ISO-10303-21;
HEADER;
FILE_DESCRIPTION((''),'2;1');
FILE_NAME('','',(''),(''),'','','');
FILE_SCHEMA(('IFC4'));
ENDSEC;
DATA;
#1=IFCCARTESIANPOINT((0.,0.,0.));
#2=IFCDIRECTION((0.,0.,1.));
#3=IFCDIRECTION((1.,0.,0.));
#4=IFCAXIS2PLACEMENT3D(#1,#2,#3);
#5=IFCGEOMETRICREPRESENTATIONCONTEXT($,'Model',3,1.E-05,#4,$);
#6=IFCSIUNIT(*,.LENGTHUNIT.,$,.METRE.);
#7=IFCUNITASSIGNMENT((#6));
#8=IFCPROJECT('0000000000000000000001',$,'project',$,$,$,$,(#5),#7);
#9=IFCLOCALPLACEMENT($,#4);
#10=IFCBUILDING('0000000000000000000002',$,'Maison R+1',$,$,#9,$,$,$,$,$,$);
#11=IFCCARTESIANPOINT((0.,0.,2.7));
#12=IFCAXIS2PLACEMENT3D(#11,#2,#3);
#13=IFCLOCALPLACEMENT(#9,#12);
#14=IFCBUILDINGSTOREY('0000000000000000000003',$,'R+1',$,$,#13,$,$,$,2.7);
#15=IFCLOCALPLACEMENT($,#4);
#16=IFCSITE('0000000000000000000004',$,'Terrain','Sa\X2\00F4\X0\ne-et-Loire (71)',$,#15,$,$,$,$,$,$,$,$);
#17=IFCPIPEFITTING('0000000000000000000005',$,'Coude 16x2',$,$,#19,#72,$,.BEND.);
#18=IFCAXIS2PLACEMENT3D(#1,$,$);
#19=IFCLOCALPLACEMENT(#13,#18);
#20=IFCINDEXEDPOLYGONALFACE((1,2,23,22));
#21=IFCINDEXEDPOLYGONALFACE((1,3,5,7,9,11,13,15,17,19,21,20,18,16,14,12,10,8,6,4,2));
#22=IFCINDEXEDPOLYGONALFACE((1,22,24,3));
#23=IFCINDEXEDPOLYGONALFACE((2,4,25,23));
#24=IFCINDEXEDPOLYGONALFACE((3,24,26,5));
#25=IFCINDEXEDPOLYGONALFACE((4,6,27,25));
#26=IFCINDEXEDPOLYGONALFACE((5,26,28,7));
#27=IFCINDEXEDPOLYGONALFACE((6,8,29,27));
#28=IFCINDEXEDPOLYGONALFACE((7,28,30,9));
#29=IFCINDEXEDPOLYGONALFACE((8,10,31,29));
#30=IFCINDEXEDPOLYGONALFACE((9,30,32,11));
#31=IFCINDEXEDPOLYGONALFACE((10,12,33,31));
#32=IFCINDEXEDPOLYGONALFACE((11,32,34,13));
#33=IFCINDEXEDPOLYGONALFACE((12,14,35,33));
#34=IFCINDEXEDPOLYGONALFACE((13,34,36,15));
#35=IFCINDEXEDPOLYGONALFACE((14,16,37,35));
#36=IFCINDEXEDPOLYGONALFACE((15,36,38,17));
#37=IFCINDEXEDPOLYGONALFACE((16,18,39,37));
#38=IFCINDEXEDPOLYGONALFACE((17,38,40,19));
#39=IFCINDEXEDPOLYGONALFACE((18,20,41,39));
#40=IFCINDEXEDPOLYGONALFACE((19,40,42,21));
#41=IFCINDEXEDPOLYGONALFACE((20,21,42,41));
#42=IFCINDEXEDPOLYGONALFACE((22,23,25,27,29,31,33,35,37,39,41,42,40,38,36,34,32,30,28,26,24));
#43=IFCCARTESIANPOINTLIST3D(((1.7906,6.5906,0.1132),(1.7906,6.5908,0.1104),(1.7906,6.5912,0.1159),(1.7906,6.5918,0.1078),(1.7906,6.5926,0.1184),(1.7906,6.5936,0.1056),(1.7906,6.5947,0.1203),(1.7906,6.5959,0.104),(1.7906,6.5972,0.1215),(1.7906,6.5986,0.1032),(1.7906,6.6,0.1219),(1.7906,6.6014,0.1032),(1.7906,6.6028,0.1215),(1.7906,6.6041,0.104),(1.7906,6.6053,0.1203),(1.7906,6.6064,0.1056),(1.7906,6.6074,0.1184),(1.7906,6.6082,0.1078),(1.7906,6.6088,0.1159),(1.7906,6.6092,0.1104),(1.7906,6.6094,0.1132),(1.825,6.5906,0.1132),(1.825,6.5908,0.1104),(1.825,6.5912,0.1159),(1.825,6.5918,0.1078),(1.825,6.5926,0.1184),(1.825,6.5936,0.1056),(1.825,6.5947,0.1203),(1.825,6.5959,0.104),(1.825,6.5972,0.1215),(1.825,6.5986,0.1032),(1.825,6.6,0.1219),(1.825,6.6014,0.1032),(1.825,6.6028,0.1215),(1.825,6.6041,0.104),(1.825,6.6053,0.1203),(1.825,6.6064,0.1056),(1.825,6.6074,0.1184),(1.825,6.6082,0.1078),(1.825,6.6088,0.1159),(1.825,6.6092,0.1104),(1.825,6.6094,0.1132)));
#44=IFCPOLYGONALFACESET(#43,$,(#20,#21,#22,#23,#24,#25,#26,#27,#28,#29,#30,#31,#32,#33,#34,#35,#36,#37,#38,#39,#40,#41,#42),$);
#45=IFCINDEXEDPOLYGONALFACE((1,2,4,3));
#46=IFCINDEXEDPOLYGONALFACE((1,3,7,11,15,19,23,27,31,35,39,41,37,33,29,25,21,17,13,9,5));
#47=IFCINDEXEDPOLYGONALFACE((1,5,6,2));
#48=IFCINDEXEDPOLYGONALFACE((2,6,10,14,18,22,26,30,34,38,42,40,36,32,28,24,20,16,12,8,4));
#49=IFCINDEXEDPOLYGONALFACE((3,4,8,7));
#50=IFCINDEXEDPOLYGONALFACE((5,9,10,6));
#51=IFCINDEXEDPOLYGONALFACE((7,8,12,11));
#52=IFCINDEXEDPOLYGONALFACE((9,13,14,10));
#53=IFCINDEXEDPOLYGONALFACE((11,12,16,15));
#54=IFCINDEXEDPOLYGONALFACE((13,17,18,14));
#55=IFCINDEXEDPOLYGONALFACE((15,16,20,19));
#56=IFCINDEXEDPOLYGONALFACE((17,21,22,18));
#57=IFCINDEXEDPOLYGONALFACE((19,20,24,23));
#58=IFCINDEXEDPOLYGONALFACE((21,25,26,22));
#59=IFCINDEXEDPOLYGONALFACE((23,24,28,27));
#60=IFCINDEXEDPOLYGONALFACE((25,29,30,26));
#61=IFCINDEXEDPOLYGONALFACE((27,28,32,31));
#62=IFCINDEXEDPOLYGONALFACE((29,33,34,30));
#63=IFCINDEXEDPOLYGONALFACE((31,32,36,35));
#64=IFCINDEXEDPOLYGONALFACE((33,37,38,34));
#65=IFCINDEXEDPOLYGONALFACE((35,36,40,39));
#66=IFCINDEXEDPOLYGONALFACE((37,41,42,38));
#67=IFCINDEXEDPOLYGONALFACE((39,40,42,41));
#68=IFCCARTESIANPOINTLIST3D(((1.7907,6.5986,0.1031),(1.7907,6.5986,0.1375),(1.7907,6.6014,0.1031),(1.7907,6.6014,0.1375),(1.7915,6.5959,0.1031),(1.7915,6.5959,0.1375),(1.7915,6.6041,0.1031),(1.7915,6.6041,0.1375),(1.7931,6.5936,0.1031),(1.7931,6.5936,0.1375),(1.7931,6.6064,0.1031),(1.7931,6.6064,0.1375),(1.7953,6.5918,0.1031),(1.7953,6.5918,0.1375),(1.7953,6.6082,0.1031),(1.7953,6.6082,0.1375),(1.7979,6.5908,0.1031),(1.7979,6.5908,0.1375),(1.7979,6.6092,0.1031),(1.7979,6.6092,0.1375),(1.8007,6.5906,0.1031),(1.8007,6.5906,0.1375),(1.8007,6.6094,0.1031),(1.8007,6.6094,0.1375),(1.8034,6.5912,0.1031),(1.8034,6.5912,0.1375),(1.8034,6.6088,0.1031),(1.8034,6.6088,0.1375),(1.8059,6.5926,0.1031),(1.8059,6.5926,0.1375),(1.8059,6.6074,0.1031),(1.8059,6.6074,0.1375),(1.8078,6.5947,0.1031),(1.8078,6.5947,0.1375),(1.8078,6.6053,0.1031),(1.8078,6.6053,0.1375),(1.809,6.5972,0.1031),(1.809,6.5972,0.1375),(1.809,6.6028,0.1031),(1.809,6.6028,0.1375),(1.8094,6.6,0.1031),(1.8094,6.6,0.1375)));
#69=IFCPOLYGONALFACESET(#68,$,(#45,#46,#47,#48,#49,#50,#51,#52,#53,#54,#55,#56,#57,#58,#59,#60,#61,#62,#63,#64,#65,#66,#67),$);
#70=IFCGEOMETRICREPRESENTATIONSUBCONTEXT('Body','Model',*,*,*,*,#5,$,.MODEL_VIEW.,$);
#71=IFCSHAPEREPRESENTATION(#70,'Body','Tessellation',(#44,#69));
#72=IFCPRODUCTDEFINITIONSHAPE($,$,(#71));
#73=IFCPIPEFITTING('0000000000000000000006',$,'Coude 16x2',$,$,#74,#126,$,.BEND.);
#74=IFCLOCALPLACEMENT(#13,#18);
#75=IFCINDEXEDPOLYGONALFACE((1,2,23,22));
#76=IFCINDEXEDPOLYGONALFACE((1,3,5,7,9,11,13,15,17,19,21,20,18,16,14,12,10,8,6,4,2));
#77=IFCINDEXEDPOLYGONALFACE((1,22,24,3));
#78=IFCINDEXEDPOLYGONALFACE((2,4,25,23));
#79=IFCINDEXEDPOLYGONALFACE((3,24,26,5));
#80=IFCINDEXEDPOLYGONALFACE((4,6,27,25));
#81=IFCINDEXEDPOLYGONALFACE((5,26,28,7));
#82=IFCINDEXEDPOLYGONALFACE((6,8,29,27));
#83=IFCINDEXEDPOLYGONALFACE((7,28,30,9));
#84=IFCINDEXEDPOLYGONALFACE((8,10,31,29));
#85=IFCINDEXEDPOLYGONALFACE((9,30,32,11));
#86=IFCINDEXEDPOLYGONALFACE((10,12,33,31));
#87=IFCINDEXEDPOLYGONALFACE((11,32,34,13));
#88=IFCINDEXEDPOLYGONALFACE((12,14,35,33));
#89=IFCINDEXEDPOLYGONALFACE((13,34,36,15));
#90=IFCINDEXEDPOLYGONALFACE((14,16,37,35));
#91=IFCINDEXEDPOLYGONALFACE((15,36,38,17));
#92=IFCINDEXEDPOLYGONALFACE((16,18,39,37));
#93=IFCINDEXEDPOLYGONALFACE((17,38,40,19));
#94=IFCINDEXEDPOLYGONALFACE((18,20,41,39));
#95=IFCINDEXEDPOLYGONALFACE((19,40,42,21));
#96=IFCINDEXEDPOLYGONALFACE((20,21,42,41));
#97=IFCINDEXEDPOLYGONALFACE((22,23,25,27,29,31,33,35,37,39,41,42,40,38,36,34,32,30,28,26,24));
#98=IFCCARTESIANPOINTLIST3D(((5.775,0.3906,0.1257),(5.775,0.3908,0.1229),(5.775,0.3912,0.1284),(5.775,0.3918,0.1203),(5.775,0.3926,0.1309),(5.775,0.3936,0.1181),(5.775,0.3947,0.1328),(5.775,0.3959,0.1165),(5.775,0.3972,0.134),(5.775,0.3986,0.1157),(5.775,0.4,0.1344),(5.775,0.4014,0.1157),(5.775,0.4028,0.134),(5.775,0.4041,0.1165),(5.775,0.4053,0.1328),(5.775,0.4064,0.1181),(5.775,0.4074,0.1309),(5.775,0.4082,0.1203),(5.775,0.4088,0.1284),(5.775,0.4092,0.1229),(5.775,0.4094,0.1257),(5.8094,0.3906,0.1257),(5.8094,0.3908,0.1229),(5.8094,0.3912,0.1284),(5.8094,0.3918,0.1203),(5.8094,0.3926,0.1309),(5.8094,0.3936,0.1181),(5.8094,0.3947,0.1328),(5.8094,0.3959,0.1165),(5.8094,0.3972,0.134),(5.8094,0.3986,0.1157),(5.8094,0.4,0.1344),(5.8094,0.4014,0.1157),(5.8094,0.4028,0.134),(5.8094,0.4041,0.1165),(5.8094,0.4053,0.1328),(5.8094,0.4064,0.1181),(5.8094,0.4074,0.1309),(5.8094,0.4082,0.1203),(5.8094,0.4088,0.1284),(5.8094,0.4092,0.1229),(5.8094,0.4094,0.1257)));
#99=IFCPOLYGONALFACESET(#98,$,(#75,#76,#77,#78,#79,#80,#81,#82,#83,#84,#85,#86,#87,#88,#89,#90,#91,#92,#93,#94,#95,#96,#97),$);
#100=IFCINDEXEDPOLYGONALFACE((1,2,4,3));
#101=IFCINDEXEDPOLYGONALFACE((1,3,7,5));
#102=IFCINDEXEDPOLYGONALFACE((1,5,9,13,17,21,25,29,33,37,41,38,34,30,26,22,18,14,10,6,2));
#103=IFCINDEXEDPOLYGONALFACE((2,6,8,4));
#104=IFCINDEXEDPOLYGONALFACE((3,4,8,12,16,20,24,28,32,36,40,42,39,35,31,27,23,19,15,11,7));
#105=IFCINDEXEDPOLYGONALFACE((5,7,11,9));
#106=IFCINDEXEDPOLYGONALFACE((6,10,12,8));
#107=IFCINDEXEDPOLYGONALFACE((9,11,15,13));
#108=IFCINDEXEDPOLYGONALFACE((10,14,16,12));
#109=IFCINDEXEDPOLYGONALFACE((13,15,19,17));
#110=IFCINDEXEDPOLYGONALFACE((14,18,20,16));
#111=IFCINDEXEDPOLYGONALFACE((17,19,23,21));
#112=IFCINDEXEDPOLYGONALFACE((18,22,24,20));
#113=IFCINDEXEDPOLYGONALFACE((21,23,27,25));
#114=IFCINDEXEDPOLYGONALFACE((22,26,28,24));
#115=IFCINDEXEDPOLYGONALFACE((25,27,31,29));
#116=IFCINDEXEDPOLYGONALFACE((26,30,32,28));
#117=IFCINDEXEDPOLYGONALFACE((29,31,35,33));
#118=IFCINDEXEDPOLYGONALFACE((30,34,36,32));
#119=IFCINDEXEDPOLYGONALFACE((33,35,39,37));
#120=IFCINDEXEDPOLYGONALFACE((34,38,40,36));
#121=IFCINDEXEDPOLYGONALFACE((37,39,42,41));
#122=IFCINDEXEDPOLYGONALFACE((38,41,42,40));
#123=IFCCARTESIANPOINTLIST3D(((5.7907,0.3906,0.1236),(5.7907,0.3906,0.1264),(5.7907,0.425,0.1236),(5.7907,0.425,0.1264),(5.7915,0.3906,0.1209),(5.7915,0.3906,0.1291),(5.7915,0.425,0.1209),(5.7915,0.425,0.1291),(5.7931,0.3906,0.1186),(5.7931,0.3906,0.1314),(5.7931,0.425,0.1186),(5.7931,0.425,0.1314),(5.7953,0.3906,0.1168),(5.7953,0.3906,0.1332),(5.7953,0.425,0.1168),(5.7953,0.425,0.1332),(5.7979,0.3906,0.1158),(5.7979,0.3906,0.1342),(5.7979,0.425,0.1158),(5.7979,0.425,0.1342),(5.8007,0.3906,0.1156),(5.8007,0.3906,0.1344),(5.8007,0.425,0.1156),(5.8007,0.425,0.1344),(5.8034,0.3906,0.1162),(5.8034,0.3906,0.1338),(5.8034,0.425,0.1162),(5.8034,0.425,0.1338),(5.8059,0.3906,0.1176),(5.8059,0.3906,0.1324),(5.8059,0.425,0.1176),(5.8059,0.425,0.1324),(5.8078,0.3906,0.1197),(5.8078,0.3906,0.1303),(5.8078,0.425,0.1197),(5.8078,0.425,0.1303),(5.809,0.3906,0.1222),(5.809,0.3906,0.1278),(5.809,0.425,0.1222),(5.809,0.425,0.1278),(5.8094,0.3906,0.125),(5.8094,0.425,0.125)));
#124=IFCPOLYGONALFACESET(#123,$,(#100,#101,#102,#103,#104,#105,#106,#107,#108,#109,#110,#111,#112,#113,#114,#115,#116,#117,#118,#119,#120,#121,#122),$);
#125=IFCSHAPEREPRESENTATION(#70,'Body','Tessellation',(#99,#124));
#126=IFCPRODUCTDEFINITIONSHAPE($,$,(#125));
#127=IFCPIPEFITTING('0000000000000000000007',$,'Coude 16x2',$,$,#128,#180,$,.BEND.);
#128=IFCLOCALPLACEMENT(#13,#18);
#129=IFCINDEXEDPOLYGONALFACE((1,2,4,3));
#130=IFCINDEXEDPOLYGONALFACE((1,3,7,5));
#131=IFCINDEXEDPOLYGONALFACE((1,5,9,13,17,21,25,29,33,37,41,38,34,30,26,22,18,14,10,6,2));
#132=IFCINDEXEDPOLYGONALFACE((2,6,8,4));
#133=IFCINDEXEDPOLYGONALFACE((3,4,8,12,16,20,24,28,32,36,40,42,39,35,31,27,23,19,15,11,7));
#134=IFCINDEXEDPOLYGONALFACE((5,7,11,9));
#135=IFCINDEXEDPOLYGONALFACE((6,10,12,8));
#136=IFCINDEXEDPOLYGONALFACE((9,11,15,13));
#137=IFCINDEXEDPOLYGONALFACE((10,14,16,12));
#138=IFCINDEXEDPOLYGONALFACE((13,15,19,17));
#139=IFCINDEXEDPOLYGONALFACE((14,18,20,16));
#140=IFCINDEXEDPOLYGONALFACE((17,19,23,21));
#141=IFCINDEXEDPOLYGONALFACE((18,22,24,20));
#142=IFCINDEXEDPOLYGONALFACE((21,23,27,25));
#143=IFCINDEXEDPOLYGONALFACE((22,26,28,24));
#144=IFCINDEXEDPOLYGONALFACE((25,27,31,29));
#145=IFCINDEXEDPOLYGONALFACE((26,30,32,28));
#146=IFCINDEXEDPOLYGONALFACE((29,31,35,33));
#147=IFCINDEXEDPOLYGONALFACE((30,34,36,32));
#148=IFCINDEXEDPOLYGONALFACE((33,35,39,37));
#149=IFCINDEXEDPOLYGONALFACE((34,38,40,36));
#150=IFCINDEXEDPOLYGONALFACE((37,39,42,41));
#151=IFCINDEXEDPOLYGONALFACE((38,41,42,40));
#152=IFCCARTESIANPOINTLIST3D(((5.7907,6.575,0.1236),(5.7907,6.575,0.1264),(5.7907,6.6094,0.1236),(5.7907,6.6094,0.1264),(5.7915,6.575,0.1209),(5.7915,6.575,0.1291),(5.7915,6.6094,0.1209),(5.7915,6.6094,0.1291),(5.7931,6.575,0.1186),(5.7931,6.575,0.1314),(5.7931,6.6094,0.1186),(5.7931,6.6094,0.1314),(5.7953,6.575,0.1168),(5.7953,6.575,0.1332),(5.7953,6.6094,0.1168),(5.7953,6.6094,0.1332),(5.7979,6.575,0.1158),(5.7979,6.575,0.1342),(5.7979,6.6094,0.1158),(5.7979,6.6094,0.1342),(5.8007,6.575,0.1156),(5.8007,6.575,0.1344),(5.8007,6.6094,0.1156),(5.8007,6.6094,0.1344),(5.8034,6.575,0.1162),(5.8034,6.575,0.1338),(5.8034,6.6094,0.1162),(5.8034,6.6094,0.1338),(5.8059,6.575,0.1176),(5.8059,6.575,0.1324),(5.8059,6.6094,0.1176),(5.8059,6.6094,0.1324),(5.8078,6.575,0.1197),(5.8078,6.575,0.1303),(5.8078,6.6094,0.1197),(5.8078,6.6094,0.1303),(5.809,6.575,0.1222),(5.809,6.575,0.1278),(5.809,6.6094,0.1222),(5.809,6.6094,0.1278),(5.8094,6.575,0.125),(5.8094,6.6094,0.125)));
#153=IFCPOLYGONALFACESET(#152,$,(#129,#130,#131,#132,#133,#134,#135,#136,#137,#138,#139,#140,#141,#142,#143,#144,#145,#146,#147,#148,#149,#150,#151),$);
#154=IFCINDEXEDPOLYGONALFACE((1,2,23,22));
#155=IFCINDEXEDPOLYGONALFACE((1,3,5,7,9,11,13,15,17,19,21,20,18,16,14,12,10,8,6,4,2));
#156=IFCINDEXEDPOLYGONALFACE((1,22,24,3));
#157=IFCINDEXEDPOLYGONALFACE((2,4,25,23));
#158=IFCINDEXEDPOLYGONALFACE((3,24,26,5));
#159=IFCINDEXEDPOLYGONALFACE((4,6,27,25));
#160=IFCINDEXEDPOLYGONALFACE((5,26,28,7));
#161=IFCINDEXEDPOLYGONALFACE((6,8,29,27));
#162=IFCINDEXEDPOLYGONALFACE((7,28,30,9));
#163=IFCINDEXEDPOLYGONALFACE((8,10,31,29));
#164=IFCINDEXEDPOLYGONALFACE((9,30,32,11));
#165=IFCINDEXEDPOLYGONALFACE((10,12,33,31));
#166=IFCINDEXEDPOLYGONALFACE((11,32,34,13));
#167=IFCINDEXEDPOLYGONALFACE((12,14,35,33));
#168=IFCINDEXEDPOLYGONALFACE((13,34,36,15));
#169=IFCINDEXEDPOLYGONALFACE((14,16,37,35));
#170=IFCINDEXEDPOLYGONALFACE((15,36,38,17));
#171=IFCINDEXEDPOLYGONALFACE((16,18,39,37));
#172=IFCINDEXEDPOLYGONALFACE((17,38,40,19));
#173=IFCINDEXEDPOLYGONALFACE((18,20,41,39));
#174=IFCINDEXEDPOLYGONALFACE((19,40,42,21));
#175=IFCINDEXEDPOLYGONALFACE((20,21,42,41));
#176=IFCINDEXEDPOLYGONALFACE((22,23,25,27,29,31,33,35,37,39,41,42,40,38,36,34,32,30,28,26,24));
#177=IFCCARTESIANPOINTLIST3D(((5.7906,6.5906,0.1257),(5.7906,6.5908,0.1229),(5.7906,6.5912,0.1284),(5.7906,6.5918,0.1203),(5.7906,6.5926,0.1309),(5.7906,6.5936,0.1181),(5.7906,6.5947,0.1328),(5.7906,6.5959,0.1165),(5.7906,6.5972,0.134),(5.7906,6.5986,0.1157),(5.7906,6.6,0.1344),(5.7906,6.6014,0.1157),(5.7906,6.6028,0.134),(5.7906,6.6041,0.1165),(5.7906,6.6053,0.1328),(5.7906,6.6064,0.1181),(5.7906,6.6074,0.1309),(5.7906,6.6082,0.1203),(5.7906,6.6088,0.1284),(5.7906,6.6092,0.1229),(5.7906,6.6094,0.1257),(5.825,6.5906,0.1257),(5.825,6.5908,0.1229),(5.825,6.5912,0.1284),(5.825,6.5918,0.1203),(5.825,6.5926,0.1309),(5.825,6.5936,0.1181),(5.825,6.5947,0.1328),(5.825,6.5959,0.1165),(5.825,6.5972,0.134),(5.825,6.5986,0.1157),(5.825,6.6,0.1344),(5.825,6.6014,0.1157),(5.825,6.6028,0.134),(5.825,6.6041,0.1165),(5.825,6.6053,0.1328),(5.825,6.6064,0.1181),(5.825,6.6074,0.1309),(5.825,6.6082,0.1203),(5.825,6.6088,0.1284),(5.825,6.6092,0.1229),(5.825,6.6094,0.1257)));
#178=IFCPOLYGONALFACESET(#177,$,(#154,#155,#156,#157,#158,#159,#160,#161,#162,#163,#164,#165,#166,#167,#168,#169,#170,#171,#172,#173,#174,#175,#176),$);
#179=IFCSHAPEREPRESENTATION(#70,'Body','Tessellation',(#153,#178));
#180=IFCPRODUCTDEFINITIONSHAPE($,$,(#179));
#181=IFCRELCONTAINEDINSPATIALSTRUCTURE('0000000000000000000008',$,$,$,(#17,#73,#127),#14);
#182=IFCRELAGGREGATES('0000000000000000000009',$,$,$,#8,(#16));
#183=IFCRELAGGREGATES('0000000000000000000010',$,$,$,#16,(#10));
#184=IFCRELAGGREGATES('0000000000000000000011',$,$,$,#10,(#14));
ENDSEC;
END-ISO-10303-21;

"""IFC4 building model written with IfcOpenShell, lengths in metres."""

from ifc_helpers import new_model, si_unit, frame, origin_with_axes, place, context, subcontext, project, spatial, circle, extrude, element, save


model = new_model("IFC4")

# Units and contexts
model_context = context("Model", 3, precision=1e-05, world=origin_with_axes())
body_context = subcontext(model_context, "Body", "Model", "MODEL_VIEW")
ifc_project = project(units=[si_unit("LENGTHUNIT", "METRE")], contexts=[model_context])

# Site, building, storey
site_placement = place(None, origin_with_axes())
site = spatial("IfcSite", under=ifc_project, at=site_placement, Name="Terrain", Description="Saône-et-Loire (71)")
building_placement = place(None, origin_with_axes())
building = spatial("IfcBuilding", under=site, at=building_placement, Name="Maison R+1")
storey_placement = place(building_placement, frame((0.0, 0.0, 2.7), z_axis=(0.0, 0.0, 1.0), x_axis=(1.0, 0.0, 0.0)))
storey = spatial("IfcBuildingStorey", under=building, at=storey_placement, Name="R+1", Elevation=2.7)

# Pipe fittings
pipe_fitting_1_placement = place(storey_placement, frame((1.8, 6.6, 0.1125), z_axis=(0.0, 0.0, 1.0), x_axis=(1.0, 0.0, 0.0)))
element("IfcPipeFitting", 1, at=pipe_fitting_1_placement, inside=storey, Name="Coude 16x2", PredefinedType="BEND", context=body_context, shape_type="SweptSolid", body=[
    extrude(circle(Radius=0.0094), frame((-0.0094, 0.0, 0.0), z_axis=(1.0, 0.0, 0.0), x_axis=(0.0, 0.0, 1.0)), (0.0, 0.0, 1.0), 0.0344),
    extrude(circle(Radius=0.0094), frame((0.0, 0.0, -0.0094), z_axis=(0.0, 0.0, 1.0), x_axis=(1.0, 0.0, 0.0)), (0.0, 0.0, 1.0), 0.0344),
])
pipe_fitting_2_placement = place(storey_placement, frame((5.8, 0.4, 0.125), z_axis=(0.0, 0.0, 1.0), x_axis=(1.0, 0.0, 0.0)))
element("IfcPipeFitting", 2, at=pipe_fitting_2_placement, inside=storey, Name="Coude 16x2", PredefinedType="BEND", context=body_context, shape_type="SweptSolid", body=[
    extrude(circle(Radius=0.0094), frame((0.0094, 0.0, 0.0), z_axis=(-1.0, 0.0, 0.0), x_axis=(0.0, 0.0, 1.0)), (0.0, 0.0, 1.0), 0.0344),
    extrude(circle(Radius=0.0094), frame((0.0, -0.0094, 0.0), z_axis=(0.0, 1.0, 0.0), x_axis=(1.0, 0.0, 0.0)), (0.0, 0.0, 1.0), 0.0344),
])
pipe_fitting_3_placement = place(storey_placement, frame((5.8, 6.6, 0.125), z_axis=(0.0, 0.0, 1.0), x_axis=(1.0, 0.0, 0.0)))
element("IfcPipeFitting", 3, at=pipe_fitting_3_placement, inside=storey, Name="Coude 16x2", PredefinedType="BEND", context=body_context, shape_type="SweptSolid", body=[
    extrude(circle(Radius=0.0094), frame((0.0, 0.0094, 0.0), z_axis=(0.0, -1.0, 0.0), x_axis=(1.0, 0.0, 0.0)), (0.0, 0.0, 1.0), 0.0344),
    extrude(circle(Radius=0.0094), frame((-0.0094, 0.0, 0.0), z_axis=(1.0, 0.0, 0.0), x_axis=(0.0, 0.0, 1.0)), (0.0, 0.0, 1.0), 0.0344),
])

save(model, "model.ifc")
